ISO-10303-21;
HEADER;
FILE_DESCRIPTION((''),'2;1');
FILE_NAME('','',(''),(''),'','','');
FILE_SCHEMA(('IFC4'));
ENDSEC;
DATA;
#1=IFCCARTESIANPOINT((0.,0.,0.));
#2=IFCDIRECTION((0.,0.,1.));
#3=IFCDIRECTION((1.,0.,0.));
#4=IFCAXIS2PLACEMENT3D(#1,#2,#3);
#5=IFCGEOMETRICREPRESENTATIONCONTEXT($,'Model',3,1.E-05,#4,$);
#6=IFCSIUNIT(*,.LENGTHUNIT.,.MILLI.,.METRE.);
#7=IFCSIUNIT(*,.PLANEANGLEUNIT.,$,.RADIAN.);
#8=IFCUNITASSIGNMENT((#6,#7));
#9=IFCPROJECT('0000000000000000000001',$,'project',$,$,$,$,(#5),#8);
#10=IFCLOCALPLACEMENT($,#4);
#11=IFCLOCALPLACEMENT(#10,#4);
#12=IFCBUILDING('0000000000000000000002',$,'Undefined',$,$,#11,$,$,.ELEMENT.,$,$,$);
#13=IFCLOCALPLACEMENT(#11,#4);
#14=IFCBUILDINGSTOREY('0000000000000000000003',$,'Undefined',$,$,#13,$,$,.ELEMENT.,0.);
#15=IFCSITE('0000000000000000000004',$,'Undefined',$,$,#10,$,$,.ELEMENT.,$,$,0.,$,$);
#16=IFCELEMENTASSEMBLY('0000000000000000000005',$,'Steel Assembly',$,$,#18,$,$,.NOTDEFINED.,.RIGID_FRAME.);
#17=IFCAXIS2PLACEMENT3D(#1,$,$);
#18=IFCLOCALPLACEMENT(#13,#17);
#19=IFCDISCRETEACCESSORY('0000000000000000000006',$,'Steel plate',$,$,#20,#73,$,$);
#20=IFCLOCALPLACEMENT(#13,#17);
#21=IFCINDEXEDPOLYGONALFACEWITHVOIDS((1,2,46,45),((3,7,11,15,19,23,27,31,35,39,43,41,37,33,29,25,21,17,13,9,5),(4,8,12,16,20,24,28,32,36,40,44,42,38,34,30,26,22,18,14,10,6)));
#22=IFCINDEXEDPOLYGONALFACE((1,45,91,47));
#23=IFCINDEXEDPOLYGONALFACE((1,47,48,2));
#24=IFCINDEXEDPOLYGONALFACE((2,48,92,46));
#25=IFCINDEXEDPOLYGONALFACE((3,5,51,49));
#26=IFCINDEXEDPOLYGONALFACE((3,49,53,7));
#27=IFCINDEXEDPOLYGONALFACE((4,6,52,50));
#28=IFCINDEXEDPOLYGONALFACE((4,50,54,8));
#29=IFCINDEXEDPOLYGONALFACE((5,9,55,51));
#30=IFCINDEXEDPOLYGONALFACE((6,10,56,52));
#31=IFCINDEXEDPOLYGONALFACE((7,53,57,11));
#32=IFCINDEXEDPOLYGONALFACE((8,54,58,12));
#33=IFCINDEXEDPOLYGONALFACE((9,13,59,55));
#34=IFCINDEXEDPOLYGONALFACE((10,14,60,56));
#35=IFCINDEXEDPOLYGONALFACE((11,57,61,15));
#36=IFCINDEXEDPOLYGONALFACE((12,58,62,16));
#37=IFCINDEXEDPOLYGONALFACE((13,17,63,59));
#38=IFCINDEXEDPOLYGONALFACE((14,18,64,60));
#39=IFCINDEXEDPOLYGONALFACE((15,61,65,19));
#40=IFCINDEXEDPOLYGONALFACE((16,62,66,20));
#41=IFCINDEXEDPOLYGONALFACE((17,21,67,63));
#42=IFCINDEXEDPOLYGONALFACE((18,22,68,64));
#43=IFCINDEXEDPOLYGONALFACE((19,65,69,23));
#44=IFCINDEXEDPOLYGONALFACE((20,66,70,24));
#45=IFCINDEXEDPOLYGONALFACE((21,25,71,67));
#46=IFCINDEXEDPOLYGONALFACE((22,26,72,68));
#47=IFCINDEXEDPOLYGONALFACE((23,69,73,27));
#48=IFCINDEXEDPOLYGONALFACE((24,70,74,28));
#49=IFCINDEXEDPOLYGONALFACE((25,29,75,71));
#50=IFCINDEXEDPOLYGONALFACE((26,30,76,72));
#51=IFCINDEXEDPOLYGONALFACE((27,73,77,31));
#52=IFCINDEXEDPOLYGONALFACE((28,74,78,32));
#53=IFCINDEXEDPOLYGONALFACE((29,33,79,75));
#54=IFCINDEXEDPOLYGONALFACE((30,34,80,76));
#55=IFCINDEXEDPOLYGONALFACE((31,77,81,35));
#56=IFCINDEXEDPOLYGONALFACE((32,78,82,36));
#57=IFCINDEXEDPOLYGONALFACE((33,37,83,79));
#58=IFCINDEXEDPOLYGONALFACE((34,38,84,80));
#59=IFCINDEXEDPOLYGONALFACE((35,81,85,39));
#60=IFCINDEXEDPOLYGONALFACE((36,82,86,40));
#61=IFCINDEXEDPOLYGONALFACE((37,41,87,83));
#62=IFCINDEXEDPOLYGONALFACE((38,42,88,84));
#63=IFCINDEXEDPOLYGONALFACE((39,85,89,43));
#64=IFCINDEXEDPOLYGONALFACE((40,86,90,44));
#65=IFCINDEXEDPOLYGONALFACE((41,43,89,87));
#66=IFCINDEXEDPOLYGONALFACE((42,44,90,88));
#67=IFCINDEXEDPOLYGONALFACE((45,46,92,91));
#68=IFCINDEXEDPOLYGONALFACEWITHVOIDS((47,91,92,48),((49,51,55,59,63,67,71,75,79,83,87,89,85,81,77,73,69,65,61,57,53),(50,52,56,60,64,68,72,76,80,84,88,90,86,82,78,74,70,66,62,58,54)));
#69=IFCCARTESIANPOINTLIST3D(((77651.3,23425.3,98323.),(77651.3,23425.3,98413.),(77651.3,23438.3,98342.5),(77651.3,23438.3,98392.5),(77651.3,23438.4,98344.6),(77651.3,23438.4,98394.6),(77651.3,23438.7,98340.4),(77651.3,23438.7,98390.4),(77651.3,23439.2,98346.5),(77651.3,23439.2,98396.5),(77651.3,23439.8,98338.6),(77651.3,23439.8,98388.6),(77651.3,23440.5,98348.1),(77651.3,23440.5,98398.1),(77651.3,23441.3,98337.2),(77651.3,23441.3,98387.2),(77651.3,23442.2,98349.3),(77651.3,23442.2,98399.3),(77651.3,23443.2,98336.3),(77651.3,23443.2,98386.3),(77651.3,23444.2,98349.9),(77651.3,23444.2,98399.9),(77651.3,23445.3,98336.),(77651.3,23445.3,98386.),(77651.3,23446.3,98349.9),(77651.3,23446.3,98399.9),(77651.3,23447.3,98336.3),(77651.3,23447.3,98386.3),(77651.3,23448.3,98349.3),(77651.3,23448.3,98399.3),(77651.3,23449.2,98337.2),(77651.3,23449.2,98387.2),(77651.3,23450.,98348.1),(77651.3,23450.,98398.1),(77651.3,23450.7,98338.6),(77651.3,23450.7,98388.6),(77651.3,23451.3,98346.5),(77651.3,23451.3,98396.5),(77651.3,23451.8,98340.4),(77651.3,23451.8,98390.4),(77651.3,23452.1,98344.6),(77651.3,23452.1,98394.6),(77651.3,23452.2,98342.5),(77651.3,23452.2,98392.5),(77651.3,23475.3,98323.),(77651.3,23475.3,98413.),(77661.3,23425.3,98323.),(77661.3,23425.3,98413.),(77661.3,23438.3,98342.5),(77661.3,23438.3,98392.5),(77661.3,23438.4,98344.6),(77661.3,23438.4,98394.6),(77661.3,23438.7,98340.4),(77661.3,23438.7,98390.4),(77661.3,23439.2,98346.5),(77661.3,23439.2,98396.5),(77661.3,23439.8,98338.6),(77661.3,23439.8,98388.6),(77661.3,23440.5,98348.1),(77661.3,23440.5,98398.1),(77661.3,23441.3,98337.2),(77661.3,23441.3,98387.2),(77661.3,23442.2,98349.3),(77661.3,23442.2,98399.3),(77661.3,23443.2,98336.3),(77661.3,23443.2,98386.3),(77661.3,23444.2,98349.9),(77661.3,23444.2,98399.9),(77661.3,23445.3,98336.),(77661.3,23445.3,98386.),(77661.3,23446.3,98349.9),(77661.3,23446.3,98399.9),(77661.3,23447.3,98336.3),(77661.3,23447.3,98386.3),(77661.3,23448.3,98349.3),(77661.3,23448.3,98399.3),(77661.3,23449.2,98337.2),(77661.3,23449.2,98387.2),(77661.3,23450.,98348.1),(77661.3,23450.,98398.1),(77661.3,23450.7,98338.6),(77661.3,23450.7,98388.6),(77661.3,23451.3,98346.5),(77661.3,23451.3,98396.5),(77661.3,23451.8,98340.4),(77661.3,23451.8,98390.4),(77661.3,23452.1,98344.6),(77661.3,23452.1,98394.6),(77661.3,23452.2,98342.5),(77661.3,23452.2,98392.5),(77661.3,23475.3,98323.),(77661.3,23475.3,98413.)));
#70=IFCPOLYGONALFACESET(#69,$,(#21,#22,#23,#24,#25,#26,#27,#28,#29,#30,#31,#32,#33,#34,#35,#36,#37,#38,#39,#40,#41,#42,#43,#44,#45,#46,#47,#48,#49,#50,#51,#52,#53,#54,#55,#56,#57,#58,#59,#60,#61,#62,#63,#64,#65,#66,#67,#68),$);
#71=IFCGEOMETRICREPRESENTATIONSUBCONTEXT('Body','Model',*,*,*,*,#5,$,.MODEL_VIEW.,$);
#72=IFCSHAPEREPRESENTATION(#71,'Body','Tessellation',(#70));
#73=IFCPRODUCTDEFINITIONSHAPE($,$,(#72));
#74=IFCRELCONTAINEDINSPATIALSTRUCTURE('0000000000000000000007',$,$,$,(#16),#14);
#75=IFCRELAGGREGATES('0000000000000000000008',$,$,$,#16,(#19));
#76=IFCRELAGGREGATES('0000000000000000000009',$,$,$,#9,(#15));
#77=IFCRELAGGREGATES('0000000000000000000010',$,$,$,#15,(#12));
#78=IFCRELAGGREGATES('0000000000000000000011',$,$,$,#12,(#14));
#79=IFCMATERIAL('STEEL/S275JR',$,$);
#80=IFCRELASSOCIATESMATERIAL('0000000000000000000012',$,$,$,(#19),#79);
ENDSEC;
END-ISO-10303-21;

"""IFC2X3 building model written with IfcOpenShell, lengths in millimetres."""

from ifc_helpers import new_model, si_unit, frame, origin_with_axes, origin_2d_with_axis, place, context, subcontext, project, spatial, polyline, circle, outline, extrude, source, transform, mapped, material, element, aggregate, save


model = new_model("IFC2X3")

# Units and contexts
model_context = context("Model", 3, precision=1e-05, world=origin_with_axes())
body_context = subcontext(model_context, "Body", "Model", "MODEL_VIEW")
ifc_project = project(units=[si_unit("LENGTHUNIT", "METRE", prefix="MILLI"), si_unit("PLANEANGLEUNIT", "RADIAN")], contexts=[model_context])

# Site, building, storey
site_placement = place(None, origin_with_axes())
site = spatial("IfcSite", under=ifc_project, at=site_placement, Name="Undefined", CompositionType="ELEMENT", RefElevation=0.0)
building_placement = place(site_placement, origin_with_axes())
building = spatial("IfcBuilding", under=site, at=building_placement, Name="Undefined", CompositionType="ELEMENT")
storey_placement = place(building_placement, origin_with_axes())
storey = spatial("IfcBuildingStorey", under=building, at=storey_placement, Name="Undefined", CompositionType="ELEMENT", Elevation=0.0)

# Shared definitions
ifc_material_1 = material(Name="STEEL/S275JR")

# Shared definitions
shared_shape_1 = source(origin_with_axes(), body_context, "Body", "SweptSolid", [
    extrude(circle(Radius=7.0, at=origin_2d_with_axis()), frame((0.0, -10.1, 0.0), z_axis=(0.0, 1.0, 0.0), x_axis=(1.0, 0.0, 0.0)), (0.0, 0.0, 1.0), 20.3),
])

# Element assembly, discrete accessory, opening
assembly_1_placement = place(storey_placement, origin_with_axes())
assembly_1 = element("IfcElementAssembly", 1, at=assembly_1_placement, inside=storey, Name="Steel Assembly", AssemblyPlace="NOTDEFINED", PredefinedType="RIGID_FRAME")
discrete_accessory_1_placement = place(assembly_1_placement, frame((77656.3, 23475.3, 98323.0), z_axis=(1.0, 0.0, 0.0), x_axis=(0.0, 0.0, 1.0)))
discrete_accessory_1 = element("IfcDiscreteAccessory", 2, at=discrete_accessory_1_placement, material=ifc_material_1, Name="Steel plate", context=body_context, shape_type="SweptSolid", body=[
    extrude(outline(polyline([(0.0, 0.0), (90.0, 0.0), (90.0, 50.0), (0.0, 50.0), (0.0, 0.0)])), frame((0.0, 0.0, -5.0), z_axis=(0.0, 0.0, 1.0), x_axis=(1.0, 0.0, 0.0)), (0.0, 0.0, 1.0), 10.0),
])
opening_1_placement = place(assembly_1_placement, frame((77651.3, 23445.3, 98393.0), z_axis=(0.0, 1.0, 0.0), x_axis=(0.0, 0.0, -1.0)))
element("IfcOpeningElement", 3, at=opening_1_placement, cuts=discrete_accessory_1, ObjectType="Opening", context=body_context, shape_type="MappedRepresentation", body=[
    mapped(shared_shape_1, transform((0.0, 0.0, 0.0))),
    mapped(shared_shape_1, transform((50.0, 0.0, 0.0))),
])
aggregate(assembly_1, [discrete_accessory_1])

save(model, "model.ifc")
